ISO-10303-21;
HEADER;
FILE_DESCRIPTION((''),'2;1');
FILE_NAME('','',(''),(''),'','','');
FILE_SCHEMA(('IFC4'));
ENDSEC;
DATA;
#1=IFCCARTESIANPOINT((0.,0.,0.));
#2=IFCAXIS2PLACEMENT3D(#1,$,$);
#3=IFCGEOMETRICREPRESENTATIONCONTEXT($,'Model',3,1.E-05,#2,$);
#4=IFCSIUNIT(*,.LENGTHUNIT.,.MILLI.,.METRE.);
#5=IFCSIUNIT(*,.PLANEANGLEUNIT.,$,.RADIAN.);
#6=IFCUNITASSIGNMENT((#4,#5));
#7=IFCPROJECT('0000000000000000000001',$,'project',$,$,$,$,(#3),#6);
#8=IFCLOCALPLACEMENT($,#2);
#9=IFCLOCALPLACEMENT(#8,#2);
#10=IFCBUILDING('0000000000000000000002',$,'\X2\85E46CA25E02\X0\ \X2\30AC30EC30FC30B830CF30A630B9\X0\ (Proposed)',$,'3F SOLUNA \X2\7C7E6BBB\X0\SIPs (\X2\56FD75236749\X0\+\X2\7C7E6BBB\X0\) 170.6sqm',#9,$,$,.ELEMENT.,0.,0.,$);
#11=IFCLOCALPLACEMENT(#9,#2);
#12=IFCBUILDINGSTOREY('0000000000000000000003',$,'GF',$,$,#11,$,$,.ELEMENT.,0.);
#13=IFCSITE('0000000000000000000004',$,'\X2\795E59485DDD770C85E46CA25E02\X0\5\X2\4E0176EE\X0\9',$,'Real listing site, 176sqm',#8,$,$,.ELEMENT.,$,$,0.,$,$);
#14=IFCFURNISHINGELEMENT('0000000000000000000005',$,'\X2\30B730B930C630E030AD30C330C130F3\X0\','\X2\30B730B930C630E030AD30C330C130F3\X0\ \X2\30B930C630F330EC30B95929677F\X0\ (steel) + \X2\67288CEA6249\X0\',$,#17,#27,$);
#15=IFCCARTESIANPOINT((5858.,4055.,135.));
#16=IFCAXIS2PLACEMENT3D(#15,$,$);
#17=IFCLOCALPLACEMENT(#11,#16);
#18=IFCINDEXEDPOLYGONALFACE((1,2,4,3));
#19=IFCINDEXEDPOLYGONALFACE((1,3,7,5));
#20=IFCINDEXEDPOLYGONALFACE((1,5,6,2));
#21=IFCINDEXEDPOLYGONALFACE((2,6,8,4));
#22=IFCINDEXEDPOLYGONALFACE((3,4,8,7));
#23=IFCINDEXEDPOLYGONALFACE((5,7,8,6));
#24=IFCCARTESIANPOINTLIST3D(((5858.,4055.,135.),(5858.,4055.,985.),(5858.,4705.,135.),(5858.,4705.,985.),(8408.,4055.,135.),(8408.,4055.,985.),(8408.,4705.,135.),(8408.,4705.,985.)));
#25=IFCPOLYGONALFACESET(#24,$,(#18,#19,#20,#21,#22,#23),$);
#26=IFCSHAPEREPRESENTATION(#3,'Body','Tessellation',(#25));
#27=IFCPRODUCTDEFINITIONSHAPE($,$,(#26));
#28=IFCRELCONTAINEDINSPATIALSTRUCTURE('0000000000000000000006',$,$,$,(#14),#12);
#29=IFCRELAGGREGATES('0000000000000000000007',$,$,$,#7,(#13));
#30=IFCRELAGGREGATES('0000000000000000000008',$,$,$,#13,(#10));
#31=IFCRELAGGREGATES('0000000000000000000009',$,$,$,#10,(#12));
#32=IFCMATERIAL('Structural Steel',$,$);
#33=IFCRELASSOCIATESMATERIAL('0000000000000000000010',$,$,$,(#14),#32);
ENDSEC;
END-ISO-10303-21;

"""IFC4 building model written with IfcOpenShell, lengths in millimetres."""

from ifc_helpers import new_model, si_unit, frame, frame_2d, origin, place, context, project, spatial, rectangle, extrude, material, element, save


model = new_model("IFC4")

# Units and contexts
model_context = context("Model", 3, precision=1e-05, world=origin())
ifc_project = project(units=[si_unit("LENGTHUNIT", "METRE", prefix="MILLI"), si_unit("PLANEANGLEUNIT", "RADIAN")], contexts=[model_context])

# Site, building, storey
site_placement = place(None, origin())
site = spatial("IfcSite", under=ifc_project, at=site_placement, Name="神奈川県藤沢市5丁目9", ObjectType="Real listing site, 176sqm", CompositionType="ELEMENT", RefElevation=0.0)
building_placement = place(site_placement, origin())
building = spatial("IfcBuilding", under=site, at=building_placement, Name="藤沢市 ガレージハウス (Proposed)", ObjectType="3F SOLUNA 籾殻SIPs (国産杉+籾殻) 170.6sqm", CompositionType="ELEMENT", ElevationOfRefHeight=0.0, ElevationOfTerrain=0.0)
storey_placement = place(building_placement, origin())
storey = spatial("IfcBuildingStorey", under=building, at=storey_placement, Name="GF", CompositionType="ELEMENT", Elevation=0.0)

# Furnishing element
ifc_material_1 = material(Name="Structural Steel")
furnishing_1_placement = place(storey_placement, frame((5858.0, 4055.0, 135.0)))
element("IfcFurnishingElement", 1, at=furnishing_1_placement, inside=storey, material=ifc_material_1, Name="システムキッチン", Description="システムキッチン ステンレス天板 (steel) + 木質扉", context=model_context, shape_type="SweptSolid", body=[
    extrude(rectangle(XDim=2550.0, YDim=650.0, at=frame_2d((1275.0, 325.0))), frame((5858.0, 4055.0, 135.0)), (0.0, 0.0, 1.0), 850.0),
])

save(model, "model.ifc")
